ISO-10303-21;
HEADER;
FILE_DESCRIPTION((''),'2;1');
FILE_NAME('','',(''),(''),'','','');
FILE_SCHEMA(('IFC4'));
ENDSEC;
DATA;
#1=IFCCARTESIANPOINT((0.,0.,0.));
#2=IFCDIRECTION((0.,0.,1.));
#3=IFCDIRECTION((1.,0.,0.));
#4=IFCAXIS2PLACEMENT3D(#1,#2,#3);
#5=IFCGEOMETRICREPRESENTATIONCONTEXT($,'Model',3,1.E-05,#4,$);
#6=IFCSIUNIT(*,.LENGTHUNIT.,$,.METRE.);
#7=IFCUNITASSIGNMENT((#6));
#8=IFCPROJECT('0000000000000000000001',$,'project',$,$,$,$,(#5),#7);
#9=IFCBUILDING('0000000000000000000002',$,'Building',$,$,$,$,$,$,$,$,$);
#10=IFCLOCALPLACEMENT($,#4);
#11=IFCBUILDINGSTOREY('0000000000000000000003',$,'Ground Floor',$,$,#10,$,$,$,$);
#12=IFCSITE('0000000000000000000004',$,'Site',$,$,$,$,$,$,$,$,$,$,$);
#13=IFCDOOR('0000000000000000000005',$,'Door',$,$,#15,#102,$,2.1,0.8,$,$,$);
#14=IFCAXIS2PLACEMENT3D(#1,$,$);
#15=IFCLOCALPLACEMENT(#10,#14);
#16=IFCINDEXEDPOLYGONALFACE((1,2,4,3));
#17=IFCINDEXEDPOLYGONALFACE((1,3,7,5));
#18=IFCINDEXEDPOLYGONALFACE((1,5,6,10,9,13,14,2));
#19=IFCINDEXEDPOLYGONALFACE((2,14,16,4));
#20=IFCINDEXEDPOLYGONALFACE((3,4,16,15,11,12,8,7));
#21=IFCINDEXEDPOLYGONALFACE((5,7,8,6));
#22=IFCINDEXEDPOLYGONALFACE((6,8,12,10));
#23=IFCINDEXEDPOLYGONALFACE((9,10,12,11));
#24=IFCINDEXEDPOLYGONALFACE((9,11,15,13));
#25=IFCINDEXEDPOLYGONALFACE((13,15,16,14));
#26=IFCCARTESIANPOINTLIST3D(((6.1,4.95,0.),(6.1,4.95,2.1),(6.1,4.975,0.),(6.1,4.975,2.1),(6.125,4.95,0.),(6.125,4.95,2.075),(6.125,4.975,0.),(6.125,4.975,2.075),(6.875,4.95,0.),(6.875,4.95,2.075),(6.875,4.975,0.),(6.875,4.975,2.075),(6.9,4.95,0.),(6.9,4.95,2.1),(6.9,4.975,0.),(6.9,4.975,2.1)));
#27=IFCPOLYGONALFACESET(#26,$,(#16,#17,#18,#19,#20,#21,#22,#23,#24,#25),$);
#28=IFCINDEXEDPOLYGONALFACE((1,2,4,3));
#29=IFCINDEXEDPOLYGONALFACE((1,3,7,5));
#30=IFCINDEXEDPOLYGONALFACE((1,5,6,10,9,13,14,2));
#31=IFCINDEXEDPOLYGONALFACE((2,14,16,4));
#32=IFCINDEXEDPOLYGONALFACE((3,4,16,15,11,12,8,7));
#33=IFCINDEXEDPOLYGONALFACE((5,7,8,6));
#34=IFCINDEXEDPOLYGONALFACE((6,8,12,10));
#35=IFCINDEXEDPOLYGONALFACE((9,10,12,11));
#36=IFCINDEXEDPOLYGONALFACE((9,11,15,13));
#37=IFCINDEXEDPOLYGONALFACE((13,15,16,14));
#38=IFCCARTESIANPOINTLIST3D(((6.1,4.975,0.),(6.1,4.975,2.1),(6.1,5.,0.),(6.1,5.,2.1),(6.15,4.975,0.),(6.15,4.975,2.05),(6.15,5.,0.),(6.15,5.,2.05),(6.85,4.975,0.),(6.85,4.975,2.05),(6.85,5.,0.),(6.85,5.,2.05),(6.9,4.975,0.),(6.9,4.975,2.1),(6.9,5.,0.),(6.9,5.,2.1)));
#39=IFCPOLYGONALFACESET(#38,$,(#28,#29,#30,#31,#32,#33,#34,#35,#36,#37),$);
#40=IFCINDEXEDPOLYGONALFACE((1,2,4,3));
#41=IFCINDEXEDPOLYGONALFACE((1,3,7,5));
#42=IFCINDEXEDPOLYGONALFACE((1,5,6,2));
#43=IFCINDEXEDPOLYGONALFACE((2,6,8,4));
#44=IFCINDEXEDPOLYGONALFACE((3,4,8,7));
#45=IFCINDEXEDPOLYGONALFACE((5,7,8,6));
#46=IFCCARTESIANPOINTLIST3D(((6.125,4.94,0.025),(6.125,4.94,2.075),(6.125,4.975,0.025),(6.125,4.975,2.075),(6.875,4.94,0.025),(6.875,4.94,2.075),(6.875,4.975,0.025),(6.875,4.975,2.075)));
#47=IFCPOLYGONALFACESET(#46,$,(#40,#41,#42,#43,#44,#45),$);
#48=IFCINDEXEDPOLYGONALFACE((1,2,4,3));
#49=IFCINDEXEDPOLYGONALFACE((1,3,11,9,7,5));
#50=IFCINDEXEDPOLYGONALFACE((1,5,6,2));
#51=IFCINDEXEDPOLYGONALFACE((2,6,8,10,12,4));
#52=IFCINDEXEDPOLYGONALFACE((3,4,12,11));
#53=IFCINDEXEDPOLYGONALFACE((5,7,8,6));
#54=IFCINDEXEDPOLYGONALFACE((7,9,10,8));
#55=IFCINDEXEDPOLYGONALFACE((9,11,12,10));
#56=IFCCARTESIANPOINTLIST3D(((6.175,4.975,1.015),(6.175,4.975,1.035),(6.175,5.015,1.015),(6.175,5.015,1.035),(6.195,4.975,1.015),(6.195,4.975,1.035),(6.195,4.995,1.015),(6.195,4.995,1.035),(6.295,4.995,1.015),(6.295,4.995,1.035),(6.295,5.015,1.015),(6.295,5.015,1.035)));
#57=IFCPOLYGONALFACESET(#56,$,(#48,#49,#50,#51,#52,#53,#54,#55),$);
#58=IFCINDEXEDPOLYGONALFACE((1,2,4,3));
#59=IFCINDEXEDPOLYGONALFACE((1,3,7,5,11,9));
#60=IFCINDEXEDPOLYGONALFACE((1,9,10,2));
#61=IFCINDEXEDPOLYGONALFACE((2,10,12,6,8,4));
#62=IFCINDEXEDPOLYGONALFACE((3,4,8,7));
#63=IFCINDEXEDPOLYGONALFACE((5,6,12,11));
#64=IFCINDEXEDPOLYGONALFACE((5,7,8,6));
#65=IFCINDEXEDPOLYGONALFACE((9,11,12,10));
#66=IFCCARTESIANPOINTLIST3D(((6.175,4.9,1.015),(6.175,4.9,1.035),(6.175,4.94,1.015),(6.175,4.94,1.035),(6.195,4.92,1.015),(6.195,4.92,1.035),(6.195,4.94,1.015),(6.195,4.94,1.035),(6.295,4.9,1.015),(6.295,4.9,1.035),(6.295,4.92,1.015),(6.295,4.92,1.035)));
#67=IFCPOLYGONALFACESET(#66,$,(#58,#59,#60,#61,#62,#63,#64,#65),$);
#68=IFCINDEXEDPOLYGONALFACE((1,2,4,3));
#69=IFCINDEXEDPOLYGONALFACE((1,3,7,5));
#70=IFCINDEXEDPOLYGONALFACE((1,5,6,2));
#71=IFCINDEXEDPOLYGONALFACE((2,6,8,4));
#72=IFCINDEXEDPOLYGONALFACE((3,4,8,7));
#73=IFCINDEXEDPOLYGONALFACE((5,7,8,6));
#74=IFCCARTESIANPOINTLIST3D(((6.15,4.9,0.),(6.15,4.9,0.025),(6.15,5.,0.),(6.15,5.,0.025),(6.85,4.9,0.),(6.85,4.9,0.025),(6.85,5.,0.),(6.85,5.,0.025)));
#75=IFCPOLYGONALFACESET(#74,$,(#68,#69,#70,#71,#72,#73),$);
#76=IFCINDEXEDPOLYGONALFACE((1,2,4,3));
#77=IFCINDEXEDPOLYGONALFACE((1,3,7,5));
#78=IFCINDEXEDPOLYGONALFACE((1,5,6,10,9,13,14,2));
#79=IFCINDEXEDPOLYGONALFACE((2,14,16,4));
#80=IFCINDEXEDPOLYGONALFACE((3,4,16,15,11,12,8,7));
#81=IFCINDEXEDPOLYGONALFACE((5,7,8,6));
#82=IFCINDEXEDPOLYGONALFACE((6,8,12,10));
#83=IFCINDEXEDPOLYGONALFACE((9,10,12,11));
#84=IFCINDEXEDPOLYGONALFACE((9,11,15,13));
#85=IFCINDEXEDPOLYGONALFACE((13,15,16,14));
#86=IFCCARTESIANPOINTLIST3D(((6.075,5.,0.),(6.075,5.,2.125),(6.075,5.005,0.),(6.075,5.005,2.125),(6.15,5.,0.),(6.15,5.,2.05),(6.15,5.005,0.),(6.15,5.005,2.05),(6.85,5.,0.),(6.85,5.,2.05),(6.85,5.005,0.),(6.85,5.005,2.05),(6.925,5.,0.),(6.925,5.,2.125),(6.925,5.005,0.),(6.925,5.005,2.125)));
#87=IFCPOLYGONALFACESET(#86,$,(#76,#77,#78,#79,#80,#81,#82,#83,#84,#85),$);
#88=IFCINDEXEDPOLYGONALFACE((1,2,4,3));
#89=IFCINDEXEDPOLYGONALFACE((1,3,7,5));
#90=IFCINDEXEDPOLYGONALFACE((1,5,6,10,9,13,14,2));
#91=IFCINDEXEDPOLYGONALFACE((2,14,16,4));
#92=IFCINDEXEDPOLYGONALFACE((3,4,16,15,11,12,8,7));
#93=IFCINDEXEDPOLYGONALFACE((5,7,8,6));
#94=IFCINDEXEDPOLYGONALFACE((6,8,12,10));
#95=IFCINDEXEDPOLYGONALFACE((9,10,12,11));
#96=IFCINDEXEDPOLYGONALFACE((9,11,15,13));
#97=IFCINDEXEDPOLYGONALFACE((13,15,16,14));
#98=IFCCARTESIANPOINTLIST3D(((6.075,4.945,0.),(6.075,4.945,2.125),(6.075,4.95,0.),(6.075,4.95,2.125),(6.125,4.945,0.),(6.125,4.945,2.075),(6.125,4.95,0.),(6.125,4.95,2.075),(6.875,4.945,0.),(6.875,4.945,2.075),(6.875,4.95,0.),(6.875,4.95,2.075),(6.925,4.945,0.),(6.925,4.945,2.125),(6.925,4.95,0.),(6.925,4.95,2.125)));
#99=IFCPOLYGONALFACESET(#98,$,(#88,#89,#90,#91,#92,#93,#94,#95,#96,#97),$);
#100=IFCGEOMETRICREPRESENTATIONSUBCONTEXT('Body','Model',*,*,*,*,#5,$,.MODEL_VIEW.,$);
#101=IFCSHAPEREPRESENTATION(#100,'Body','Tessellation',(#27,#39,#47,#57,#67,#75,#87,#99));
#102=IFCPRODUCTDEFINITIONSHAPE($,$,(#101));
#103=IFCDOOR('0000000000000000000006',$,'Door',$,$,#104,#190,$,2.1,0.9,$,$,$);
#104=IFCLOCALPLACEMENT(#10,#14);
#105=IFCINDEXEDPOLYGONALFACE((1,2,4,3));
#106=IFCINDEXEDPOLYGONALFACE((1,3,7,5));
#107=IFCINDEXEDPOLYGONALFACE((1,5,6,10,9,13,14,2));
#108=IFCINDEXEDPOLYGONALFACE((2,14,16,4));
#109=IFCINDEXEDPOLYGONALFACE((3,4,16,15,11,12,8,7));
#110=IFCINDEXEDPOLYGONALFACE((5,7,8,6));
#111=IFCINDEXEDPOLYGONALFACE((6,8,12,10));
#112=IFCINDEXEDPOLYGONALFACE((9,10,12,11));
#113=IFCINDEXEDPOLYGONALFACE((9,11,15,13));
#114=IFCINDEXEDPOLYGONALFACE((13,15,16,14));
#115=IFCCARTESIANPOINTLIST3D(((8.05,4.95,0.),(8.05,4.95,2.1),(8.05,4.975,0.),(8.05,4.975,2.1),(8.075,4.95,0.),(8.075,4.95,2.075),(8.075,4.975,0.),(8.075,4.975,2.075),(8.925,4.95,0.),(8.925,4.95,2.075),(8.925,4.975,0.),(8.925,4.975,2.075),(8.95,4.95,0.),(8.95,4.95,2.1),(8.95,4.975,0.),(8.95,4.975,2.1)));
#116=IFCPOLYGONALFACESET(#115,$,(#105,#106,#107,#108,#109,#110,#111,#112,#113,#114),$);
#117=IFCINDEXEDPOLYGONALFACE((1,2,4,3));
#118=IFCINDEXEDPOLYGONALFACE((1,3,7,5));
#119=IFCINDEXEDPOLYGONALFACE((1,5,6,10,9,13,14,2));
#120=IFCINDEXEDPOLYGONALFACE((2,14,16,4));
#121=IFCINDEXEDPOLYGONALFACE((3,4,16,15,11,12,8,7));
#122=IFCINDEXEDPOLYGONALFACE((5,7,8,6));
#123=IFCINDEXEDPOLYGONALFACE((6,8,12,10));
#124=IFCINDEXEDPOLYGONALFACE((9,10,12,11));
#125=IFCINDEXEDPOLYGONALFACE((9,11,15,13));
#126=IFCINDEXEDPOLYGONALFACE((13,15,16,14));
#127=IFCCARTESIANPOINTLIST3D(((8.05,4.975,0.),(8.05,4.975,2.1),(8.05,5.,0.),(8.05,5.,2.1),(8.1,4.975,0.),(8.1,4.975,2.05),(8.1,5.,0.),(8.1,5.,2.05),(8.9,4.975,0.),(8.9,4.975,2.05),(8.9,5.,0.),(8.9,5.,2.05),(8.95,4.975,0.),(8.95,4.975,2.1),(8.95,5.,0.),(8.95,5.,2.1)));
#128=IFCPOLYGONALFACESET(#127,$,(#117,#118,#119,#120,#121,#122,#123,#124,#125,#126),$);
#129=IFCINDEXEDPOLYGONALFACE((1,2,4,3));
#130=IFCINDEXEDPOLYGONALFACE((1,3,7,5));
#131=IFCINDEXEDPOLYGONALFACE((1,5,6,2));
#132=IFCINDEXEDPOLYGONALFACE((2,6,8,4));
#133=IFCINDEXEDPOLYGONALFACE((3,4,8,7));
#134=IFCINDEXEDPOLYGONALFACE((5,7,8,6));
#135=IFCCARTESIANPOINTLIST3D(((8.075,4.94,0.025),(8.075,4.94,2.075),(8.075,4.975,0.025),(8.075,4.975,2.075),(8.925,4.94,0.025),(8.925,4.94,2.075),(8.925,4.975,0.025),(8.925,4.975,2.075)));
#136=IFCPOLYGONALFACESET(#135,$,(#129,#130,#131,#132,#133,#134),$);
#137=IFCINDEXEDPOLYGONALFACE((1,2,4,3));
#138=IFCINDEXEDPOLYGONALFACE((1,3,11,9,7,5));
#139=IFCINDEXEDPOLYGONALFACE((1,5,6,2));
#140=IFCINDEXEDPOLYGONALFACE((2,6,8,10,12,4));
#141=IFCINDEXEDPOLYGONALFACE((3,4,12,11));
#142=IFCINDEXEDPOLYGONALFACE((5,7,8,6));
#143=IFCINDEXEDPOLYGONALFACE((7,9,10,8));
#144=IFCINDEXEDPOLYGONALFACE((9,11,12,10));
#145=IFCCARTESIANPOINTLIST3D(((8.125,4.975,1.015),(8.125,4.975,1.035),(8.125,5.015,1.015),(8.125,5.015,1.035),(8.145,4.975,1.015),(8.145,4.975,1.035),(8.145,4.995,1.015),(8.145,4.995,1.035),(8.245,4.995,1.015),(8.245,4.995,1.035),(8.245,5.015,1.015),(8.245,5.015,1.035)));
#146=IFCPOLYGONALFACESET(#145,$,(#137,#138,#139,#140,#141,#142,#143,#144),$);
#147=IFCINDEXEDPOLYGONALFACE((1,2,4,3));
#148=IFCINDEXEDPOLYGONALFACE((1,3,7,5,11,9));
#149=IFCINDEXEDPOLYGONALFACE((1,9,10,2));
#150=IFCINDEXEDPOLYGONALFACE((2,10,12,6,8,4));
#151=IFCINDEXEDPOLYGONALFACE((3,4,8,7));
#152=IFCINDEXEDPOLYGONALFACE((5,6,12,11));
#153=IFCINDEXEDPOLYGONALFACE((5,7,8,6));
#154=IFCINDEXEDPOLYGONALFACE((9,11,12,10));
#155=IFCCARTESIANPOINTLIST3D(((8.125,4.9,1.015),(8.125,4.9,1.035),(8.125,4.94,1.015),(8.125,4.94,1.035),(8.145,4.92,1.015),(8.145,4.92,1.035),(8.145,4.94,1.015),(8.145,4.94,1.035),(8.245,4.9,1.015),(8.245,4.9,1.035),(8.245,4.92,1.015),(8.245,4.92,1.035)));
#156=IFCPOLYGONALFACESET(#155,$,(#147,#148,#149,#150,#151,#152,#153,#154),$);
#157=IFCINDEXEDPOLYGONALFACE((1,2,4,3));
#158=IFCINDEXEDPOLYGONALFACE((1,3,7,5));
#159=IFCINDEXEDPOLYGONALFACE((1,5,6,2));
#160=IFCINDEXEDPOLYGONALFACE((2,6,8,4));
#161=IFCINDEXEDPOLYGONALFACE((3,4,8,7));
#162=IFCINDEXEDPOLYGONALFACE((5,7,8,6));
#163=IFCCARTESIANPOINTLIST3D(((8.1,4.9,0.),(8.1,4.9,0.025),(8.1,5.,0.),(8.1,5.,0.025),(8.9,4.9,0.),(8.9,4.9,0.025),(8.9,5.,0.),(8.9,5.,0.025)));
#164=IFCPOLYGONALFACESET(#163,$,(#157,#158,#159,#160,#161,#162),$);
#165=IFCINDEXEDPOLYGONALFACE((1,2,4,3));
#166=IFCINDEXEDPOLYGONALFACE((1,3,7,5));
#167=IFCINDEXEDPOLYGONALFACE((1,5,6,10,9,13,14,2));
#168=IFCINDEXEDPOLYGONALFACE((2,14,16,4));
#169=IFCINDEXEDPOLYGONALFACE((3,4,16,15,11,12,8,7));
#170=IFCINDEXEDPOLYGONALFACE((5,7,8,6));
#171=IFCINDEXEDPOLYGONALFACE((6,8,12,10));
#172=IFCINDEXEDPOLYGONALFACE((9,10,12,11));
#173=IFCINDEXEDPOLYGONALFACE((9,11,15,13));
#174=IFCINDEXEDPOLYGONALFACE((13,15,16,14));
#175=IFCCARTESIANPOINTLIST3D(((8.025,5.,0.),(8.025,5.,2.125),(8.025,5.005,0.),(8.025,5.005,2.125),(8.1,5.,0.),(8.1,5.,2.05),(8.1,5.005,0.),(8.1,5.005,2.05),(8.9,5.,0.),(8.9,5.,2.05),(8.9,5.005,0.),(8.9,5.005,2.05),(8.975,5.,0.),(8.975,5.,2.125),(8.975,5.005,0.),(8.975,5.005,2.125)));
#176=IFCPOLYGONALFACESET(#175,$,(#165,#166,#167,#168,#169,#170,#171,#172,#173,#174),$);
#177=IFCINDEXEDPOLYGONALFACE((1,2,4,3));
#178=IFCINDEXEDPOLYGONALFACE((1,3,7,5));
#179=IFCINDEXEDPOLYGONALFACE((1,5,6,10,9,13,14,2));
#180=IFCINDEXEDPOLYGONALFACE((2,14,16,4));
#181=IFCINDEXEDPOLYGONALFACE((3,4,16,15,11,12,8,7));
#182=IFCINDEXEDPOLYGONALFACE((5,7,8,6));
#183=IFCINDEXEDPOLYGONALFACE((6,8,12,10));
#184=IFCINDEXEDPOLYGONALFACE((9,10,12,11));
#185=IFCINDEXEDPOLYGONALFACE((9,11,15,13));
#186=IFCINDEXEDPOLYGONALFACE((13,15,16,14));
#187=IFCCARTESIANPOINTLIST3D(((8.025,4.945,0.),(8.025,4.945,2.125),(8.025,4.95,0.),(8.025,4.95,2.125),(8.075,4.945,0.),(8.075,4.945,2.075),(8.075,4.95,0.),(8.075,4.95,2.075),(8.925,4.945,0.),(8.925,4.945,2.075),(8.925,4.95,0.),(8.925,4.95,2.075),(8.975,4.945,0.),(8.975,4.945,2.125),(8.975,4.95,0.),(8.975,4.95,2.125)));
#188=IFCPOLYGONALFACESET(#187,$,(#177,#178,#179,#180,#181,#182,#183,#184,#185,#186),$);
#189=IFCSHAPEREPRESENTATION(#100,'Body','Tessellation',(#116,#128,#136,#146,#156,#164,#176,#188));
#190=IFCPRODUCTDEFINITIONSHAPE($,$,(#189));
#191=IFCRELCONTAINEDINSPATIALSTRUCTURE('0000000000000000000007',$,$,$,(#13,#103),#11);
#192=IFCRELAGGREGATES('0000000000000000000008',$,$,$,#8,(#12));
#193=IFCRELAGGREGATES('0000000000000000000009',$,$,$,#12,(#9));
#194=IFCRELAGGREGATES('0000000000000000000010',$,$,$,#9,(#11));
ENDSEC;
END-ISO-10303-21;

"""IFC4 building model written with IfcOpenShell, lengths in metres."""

from ifc_helpers import new_model, si_unit, frame, origin_with_axes, place, context, subcontext, project, spatial, line, indexed_curve, outline, extrude, element, save


model = new_model("IFC4")

# Units and contexts
model_context = context("Model", 3, precision=1e-05, world=origin_with_axes())
body_context = subcontext(model_context, "Body", "Model", "MODEL_VIEW")
ifc_project = project(units=[si_unit("LENGTHUNIT", "METRE")], contexts=[model_context])

# Site, building, storey
site = spatial("IfcSite", under=ifc_project, Name="Site")
building = spatial("IfcBuilding", under=site, Name="Building")
storey_placement = place(None, origin_with_axes())
storey = spatial("IfcBuildingStorey", under=building, at=storey_placement, Name="Ground Floor")

# Doors
door_1_placement = place(storey_placement, frame((6.9, 5.0, 0.0), z_axis=(0.0, 0.0, 1.0), x_axis=(-1.0, 0.0, 0.0)))
element("IfcDoor", 1, at=door_1_placement, inside=storey, Name="Door", OverallHeight=2.1, OverallWidth=0.8, context=body_context, shape_type="SweptSolid", body=[
    extrude(outline(indexed_curve([(0.0, 0.0), (0.0, 2.1), (0.8, 2.1), (0.8, 0.0), (0.775, 0.0), (0.775, 2.075), (0.025, 2.075), (0.025, 0.0)], segments=[line(1, 2, 3, 4, 5, 6, 7, 8, 1)])), frame((0.0, 0.025, 0.0), z_axis=(0.0, -1.0, 0.0), x_axis=(1.0, 0.0, 0.0)), (0.0, 0.0, -1.0), 0.025),
    extrude(outline(indexed_curve([(0.0, 0.0), (0.0, 2.1), (0.8, 2.1), (0.8, 0.0), (0.75, 0.0), (0.75, 2.05), (0.05, 2.05), (0.05, 0.0)], segments=[line(1, 2, 3, 4, 5, 6, 7, 8, 1)])), frame((0.0, 0.0, 0.0), z_axis=(0.0, -1.0, 0.0), x_axis=(1.0, 0.0, 0.0)), (0.0, 0.0, -1.0), 0.025),
    extrude(outline(indexed_curve([(0.0, 0.0), (0.75, 0.0), (0.75, 0.035), (0.0, 0.035)], segments=[line(1, 2, 3, 4, 1)])), frame((0.025, 0.025, 0.025), z_axis=(0.0, 0.0, 1.0), x_axis=(1.0, 0.0, 0.0)), (0.0, 0.0, 1.0), 2.05),
    extrude(outline(indexed_curve([(0.0, 0.0), (0.0, -0.04), (-0.12, -0.04), (-0.12, -0.02), (-0.02, -0.02), (-0.02, 0.0)], segments=[line(1, 2, 3, 4, 5, 6, 1)])), frame((0.725, 0.025, 1.015), z_axis=(0.0, 0.0, 1.0), x_axis=(1.0, 0.0, 0.0)), (0.0, 0.0, 1.0), 0.02),
    extrude(outline(indexed_curve([(0.0, 0.0), (0.0, 0.04), (-0.12, 0.04), (-0.12, 0.02), (-0.02, 0.02), (-0.02, 0.0)], segments=[line(1, 2, 3, 4, 5, 6, 1)])), frame((0.725, 0.06, 1.015), z_axis=(0.0, 0.0, 1.0), x_axis=(1.0, 0.0, 0.0)), (0.0, 0.0, 1.0), 0.02),
    extrude(outline(indexed_curve([(0.0, 0.0), (0.7, 0.0), (0.7, 0.1), (0.0, 0.1)], segments=[line(1, 2, 3, 4, 1)])), frame((0.05, 0.0, 0.0), z_axis=(0.0, 0.0, 1.0), x_axis=(1.0, 0.0, 0.0)), (0.0, 0.0, 1.0), 0.025),
    extrude(outline(indexed_curve([(0.0, 0.0), (0.0, 2.125), (0.85, 2.125), (0.85, 0.0), (0.775, 0.0), (0.775, 2.05), (0.075, 2.05), (0.075, 0.0)], segments=[line(1, 2, 3, 4, 5, 6, 7, 8, 1)])), frame((-0.025, -0.005, 0.0), z_axis=(0.0, -1.0, 0.0), x_axis=(1.0, 0.0, 0.0)), (0.0, 0.0, -1.0), 0.005),
    extrude(outline(indexed_curve([(0.0, 0.0), (0.0, 2.125), (0.85, 2.125), (0.85, 0.0), (0.8, 0.0), (0.8, 2.075), (0.05, 2.075), (0.05, 0.0)], segments=[line(1, 2, 3, 4, 5, 6, 7, 8, 1)])), frame((-0.025, 0.05, 0.0), z_axis=(0.0, -1.0, 0.0), x_axis=(1.0, 0.0, 0.0)), (0.0, 0.0, -1.0), 0.005),
])
door_2_placement = place(storey_placement, frame((8.95, 5.0, 0.0), z_axis=(0.0, 0.0, 1.0), x_axis=(-1.0, 0.0, 0.0)))
element("IfcDoor", 2, at=door_2_placement, inside=storey, Name="Door", OverallHeight=2.1, OverallWidth=0.9, context=body_context, shape_type="SweptSolid", body=[
    extrude(outline(indexed_curve([(0.0, 0.0), (0.0, 2.1), (0.9, 2.1), (0.9, 0.0), (0.875, 0.0), (0.875, 2.075), (0.025, 2.075), (0.025, 0.0)], segments=[line(1, 2, 3, 4, 5, 6, 7, 8, 1)])), frame((0.0, 0.025, 0.0), z_axis=(0.0, -1.0, 0.0), x_axis=(1.0, 0.0, 0.0)), (0.0, 0.0, -1.0), 0.025),
    extrude(outline(indexed_curve([(0.0, 0.0), (0.0, 2.1), (0.9, 2.1), (0.9, 0.0), (0.85, 0.0), (0.85, 2.05), (0.05, 2.05), (0.05, 0.0)], segments=[line(1, 2, 3, 4, 5, 6, 7, 8, 1)])), frame((0.0, 0.0, 0.0), z_axis=(0.0, -1.0, 0.0), x_axis=(1.0, 0.0, 0.0)), (0.0, 0.0, -1.0), 0.025),
    extrude(outline(indexed_curve([(0.0, 0.0), (0.85, 0.0), (0.85, 0.035), (0.0, 0.035)], segments=[line(1, 2, 3, 4, 1)])), frame((0.025, 0.025, 0.025), z_axis=(0.0, 0.0, 1.0), x_axis=(1.0, 0.0, 0.0)), (0.0, 0.0, 1.0), 2.05),
    extrude(outline(indexed_curve([(0.0, 0.0), (0.0, -0.04), (-0.12, -0.04), (-0.12, -0.02), (-0.02, -0.02), (-0.02, 0.0)], segments=[line(1, 2, 3, 4, 5, 6, 1)])), frame((0.825, 0.025, 1.015), z_axis=(0.0, 0.0, 1.0), x_axis=(1.0, 0.0, 0.0)), (0.0, 0.0, 1.0), 0.02),
    extrude(outline(indexed_curve([(0.0, 0.0), (0.0, 0.04), (-0.12, 0.04), (-0.12, 0.02), (-0.02, 0.02), (-0.02, 0.0)], segments=[line(1, 2, 3, 4, 5, 6, 1)])), frame((0.825, 0.06, 1.015), z_axis=(0.0, 0.0, 1.0), x_axis=(1.0, 0.0, 0.0)), (0.0, 0.0, 1.0), 0.02),
    extrude(outline(indexed_curve([(0.0, 0.0), (0.8, 0.0), (0.8, 0.1), (0.0, 0.1)], segments=[line(1, 2, 3, 4, 1)])), frame((0.05, 0.0, 0.0), z_axis=(0.0, 0.0, 1.0), x_axis=(1.0, 0.0, 0.0)), (0.0, 0.0, 1.0), 0.025),
    extrude(outline(indexed_curve([(0.0, 0.0), (0.0, 2.125), (0.95, 2.125), (0.95, 0.0), (0.875, 0.0), (0.875, 2.05), (0.075, 2.05), (0.075, 0.0)], segments=[line(1, 2, 3, 4, 5, 6, 7, 8, 1)])), frame((-0.025, -0.005, 0.0), z_axis=(0.0, -1.0, 0.0), x_axis=(1.0, 0.0, 0.0)), (0.0, 0.0, -1.0), 0.005),
    extrude(outline(indexed_curve([(0.0, 0.0), (0.0, 2.125), (0.95, 2.125), (0.95, 0.0), (0.9, 0.0), (0.9, 2.075), (0.05, 2.075), (0.05, 0.0)], segments=[line(1, 2, 3, 4, 5, 6, 7, 8, 1)])), frame((-0.025, 0.05, 0.0), z_axis=(0.0, -1.0, 0.0), x_axis=(1.0, 0.0, 0.0)), (0.0, 0.0, -1.0), 0.005),
])

save(model, "model.ifc")
